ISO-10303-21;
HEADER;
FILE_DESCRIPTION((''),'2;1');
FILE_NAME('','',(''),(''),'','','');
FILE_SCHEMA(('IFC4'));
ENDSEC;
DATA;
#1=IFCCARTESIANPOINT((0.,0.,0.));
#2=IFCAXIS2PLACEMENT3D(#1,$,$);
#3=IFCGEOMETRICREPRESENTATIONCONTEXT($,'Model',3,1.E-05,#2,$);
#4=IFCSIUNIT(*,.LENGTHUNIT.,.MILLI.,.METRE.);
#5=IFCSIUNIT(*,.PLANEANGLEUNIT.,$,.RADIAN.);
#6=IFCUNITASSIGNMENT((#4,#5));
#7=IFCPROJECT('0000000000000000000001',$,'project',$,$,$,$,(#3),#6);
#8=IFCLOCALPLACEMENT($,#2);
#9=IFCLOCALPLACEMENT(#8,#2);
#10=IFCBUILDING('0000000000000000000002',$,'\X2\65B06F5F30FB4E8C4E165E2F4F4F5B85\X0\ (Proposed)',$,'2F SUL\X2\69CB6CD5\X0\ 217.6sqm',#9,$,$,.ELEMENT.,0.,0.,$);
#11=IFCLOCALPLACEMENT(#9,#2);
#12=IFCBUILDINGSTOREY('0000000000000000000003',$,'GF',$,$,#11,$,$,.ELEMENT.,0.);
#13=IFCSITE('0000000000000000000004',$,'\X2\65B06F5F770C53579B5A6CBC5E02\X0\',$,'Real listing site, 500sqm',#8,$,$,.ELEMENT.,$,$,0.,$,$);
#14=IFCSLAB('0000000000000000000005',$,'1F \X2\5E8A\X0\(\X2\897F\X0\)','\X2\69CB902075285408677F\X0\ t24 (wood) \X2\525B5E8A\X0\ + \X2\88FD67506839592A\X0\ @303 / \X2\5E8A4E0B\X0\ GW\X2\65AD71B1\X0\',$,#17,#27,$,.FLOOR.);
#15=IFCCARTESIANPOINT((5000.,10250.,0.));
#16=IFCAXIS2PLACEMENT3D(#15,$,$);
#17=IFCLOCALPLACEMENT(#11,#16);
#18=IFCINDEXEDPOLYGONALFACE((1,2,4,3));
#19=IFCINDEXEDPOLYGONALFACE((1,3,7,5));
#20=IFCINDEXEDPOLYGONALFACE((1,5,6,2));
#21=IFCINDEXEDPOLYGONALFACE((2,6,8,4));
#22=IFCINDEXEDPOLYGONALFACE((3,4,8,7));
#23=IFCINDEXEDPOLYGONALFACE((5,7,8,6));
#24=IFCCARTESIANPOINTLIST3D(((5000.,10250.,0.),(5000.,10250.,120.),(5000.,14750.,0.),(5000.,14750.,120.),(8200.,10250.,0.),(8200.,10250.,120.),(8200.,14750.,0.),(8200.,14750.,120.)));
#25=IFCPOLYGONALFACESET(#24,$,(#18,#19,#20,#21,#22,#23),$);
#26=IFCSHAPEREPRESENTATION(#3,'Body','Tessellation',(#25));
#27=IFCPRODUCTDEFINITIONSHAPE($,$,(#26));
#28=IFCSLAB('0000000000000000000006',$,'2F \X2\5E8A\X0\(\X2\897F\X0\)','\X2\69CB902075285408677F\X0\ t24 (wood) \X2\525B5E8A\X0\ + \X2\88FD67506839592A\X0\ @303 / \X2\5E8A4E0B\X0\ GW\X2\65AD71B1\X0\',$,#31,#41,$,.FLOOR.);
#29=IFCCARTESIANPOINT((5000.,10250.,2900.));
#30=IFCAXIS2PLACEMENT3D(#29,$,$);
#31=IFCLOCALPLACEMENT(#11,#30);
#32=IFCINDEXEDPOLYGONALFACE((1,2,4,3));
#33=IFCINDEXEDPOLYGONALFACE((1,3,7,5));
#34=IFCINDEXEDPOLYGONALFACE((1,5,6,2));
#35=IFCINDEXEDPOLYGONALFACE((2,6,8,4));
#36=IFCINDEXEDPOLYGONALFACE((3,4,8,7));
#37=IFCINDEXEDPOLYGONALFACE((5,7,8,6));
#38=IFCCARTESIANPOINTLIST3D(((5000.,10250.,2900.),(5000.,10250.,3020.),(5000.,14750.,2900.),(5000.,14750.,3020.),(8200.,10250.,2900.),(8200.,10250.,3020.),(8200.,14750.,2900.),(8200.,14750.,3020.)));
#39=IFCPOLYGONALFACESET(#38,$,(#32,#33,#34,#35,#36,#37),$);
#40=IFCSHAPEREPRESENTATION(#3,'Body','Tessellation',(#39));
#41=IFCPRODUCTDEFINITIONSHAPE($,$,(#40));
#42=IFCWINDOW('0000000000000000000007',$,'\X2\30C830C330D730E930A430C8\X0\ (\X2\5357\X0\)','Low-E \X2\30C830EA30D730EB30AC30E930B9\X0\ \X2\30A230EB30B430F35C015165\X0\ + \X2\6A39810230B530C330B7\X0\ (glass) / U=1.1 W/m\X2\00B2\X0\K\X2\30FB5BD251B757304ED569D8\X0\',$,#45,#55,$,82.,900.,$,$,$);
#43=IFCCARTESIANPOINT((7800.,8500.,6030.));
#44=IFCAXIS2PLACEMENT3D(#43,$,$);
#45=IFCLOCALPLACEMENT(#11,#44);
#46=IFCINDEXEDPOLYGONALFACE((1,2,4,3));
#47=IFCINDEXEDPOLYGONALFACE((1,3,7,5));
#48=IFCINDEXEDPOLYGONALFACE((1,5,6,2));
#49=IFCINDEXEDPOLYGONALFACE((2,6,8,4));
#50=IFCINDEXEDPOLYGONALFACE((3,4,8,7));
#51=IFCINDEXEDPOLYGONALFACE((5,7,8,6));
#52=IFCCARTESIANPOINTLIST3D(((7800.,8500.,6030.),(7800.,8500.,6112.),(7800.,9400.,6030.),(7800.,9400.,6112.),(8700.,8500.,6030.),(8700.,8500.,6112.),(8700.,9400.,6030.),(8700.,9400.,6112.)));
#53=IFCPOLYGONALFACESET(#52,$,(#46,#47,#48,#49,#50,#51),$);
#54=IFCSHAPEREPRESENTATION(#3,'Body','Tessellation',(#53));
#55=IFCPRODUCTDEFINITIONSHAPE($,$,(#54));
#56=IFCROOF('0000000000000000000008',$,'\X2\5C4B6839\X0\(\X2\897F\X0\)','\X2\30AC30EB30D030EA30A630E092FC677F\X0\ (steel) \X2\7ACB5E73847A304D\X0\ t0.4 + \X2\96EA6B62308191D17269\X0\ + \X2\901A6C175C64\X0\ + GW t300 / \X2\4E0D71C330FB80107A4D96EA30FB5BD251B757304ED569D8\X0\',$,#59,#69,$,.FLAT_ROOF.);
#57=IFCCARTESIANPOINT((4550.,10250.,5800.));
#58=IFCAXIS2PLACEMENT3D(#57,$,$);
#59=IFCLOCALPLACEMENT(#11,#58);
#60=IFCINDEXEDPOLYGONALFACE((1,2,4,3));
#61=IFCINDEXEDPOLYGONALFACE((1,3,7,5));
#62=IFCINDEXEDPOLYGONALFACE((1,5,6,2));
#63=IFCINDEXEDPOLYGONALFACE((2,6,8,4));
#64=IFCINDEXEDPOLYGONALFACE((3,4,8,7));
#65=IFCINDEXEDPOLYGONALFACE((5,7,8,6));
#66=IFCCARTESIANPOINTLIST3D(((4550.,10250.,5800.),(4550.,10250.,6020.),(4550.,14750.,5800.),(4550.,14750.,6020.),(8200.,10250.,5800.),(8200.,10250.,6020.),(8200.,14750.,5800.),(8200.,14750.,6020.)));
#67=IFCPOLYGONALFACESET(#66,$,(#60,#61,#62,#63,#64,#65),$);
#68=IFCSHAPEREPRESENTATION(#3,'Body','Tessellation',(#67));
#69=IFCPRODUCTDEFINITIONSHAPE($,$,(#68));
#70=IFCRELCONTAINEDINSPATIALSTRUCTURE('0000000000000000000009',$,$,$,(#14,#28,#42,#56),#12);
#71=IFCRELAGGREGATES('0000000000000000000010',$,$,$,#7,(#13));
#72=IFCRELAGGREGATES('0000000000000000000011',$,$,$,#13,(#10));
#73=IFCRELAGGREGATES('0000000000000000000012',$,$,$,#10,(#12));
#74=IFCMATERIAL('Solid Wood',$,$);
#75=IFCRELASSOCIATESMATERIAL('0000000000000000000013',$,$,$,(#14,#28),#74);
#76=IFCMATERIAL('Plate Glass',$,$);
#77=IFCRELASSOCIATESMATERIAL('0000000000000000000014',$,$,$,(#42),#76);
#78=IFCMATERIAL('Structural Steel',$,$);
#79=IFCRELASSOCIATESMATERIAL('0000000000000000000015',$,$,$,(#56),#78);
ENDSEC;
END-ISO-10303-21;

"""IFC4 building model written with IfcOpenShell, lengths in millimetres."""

from ifc_helpers import new_model, si_unit, frame, frame_2d, origin, place, context, project, spatial, rectangle, extrude, material, element, save


model = new_model("IFC4")

# Units and contexts
model_context = context("Model", 3, precision=1e-05, world=origin())
ifc_project = project(units=[si_unit("LENGTHUNIT", "METRE", prefix="MILLI"), si_unit("PLANEANGLEUNIT", "RADIAN")], contexts=[model_context])

# Site, building, storey
site_placement = place(None, origin())
site = spatial("IfcSite", under=ifc_project, at=site_placement, Name="新潟県南魚沼市", ObjectType="Real listing site, 500sqm", CompositionType="ELEMENT", RefElevation=0.0)
building_placement = place(site_placement, origin())
building = spatial("IfcBuilding", under=site, at=building_placement, Name="新潟・二世帯住宅 (Proposed)", ObjectType="2F SUL構法 217.6sqm", CompositionType="ELEMENT", ElevationOfRefHeight=0.0, ElevationOfTerrain=0.0)
storey_placement = place(building_placement, origin())
storey = spatial("IfcBuildingStorey", under=building, at=storey_placement, Name="GF", CompositionType="ELEMENT", Elevation=0.0)

# Shared definitions
ifc_material_1 = material(Name="Solid Wood")

# Slabs
slab_1_placement = place(storey_placement, frame((5000.0, 10250.0, 0.0)))
element("IfcSlab", 1, at=slab_1_placement, inside=storey, material=ifc_material_1, Name="1F 床(西)", Description="構造用合板 t24 (wood) 剛床 + 製材根太 @303 / 床下 GW断熱", PredefinedType="FLOOR", context=model_context, shape_type="SweptSolid", body=[
    extrude(rectangle(XDim=3200.0, YDim=4500.0, at=frame_2d((1600.0, 2250.0))), frame((5000.0, 10250.0, 0.0)), (0.0, 0.0, 1.0), 120.0),
])
slab_2_placement = place(storey_placement, frame((5000.0, 10250.0, 2900.0)))
element("IfcSlab", 2, at=slab_2_placement, inside=storey, material=ifc_material_1, Name="2F 床(西)", Description="構造用合板 t24 (wood) 剛床 + 製材根太 @303 / 床下 GW断熱", PredefinedType="FLOOR", context=model_context, shape_type="SweptSolid", body=[
    extrude(rectangle(XDim=3200.0, YDim=4500.0, at=frame_2d((1600.0, 2250.0))), frame((5000.0, 10250.0, 2900.0)), (0.0, 0.0, 1.0), 120.0),
])

# Window
ifc_material_2 = material(Name="Plate Glass")
window_placement = place(storey_placement, frame((7800.0, 8500.0, 6030.0)))
element("IfcWindow", 3, at=window_placement, inside=storey, material=ifc_material_2, Name="トップライト (南)", Description="Low-E トリプルガラス アルゴン封入 + 樹脂サッシ (glass) / U=1.1 W/m²K・寒冷地仕様", OverallHeight=82.0, OverallWidth=900.0, context=model_context, shape_type="SweptSolid", body=[
    extrude(rectangle(XDim=900.0, YDim=900.0, at=frame_2d((450.0, 450.0))), frame((7800.0, 8500.0, 6030.0)), (0.0, 0.0, 1.0), 82.0),
])

# Roof
ifc_material_3 = material(Name="Structural Steel")
for number, where, name in (
    (4, (4550.0, 10250.0, 5800.0), "屋根(西)"),
):
    element("IfcRoof", number, at=place(storey_placement, frame(where)), inside=storey, material=ifc_material_3, Name=name, Description="ガルバリウム鋼板 (steel) 立平葺き t0.4 + 雪止め金物 + 通気層 + GW t300 / 不燃・耐積雪・寒冷地仕様", PredefinedType="FLAT_ROOF", context=model_context, shape_type="SweptSolid", body=[
        extrude(rectangle(XDim=3650.0, YDim=4500.0, at=frame_2d((1825.0, 2250.0))), frame((4550.0, 10250.0, 5800.0)), (0.0, 0.0, 1.0), 220.0),
    ])

save(model, "model.ifc")
